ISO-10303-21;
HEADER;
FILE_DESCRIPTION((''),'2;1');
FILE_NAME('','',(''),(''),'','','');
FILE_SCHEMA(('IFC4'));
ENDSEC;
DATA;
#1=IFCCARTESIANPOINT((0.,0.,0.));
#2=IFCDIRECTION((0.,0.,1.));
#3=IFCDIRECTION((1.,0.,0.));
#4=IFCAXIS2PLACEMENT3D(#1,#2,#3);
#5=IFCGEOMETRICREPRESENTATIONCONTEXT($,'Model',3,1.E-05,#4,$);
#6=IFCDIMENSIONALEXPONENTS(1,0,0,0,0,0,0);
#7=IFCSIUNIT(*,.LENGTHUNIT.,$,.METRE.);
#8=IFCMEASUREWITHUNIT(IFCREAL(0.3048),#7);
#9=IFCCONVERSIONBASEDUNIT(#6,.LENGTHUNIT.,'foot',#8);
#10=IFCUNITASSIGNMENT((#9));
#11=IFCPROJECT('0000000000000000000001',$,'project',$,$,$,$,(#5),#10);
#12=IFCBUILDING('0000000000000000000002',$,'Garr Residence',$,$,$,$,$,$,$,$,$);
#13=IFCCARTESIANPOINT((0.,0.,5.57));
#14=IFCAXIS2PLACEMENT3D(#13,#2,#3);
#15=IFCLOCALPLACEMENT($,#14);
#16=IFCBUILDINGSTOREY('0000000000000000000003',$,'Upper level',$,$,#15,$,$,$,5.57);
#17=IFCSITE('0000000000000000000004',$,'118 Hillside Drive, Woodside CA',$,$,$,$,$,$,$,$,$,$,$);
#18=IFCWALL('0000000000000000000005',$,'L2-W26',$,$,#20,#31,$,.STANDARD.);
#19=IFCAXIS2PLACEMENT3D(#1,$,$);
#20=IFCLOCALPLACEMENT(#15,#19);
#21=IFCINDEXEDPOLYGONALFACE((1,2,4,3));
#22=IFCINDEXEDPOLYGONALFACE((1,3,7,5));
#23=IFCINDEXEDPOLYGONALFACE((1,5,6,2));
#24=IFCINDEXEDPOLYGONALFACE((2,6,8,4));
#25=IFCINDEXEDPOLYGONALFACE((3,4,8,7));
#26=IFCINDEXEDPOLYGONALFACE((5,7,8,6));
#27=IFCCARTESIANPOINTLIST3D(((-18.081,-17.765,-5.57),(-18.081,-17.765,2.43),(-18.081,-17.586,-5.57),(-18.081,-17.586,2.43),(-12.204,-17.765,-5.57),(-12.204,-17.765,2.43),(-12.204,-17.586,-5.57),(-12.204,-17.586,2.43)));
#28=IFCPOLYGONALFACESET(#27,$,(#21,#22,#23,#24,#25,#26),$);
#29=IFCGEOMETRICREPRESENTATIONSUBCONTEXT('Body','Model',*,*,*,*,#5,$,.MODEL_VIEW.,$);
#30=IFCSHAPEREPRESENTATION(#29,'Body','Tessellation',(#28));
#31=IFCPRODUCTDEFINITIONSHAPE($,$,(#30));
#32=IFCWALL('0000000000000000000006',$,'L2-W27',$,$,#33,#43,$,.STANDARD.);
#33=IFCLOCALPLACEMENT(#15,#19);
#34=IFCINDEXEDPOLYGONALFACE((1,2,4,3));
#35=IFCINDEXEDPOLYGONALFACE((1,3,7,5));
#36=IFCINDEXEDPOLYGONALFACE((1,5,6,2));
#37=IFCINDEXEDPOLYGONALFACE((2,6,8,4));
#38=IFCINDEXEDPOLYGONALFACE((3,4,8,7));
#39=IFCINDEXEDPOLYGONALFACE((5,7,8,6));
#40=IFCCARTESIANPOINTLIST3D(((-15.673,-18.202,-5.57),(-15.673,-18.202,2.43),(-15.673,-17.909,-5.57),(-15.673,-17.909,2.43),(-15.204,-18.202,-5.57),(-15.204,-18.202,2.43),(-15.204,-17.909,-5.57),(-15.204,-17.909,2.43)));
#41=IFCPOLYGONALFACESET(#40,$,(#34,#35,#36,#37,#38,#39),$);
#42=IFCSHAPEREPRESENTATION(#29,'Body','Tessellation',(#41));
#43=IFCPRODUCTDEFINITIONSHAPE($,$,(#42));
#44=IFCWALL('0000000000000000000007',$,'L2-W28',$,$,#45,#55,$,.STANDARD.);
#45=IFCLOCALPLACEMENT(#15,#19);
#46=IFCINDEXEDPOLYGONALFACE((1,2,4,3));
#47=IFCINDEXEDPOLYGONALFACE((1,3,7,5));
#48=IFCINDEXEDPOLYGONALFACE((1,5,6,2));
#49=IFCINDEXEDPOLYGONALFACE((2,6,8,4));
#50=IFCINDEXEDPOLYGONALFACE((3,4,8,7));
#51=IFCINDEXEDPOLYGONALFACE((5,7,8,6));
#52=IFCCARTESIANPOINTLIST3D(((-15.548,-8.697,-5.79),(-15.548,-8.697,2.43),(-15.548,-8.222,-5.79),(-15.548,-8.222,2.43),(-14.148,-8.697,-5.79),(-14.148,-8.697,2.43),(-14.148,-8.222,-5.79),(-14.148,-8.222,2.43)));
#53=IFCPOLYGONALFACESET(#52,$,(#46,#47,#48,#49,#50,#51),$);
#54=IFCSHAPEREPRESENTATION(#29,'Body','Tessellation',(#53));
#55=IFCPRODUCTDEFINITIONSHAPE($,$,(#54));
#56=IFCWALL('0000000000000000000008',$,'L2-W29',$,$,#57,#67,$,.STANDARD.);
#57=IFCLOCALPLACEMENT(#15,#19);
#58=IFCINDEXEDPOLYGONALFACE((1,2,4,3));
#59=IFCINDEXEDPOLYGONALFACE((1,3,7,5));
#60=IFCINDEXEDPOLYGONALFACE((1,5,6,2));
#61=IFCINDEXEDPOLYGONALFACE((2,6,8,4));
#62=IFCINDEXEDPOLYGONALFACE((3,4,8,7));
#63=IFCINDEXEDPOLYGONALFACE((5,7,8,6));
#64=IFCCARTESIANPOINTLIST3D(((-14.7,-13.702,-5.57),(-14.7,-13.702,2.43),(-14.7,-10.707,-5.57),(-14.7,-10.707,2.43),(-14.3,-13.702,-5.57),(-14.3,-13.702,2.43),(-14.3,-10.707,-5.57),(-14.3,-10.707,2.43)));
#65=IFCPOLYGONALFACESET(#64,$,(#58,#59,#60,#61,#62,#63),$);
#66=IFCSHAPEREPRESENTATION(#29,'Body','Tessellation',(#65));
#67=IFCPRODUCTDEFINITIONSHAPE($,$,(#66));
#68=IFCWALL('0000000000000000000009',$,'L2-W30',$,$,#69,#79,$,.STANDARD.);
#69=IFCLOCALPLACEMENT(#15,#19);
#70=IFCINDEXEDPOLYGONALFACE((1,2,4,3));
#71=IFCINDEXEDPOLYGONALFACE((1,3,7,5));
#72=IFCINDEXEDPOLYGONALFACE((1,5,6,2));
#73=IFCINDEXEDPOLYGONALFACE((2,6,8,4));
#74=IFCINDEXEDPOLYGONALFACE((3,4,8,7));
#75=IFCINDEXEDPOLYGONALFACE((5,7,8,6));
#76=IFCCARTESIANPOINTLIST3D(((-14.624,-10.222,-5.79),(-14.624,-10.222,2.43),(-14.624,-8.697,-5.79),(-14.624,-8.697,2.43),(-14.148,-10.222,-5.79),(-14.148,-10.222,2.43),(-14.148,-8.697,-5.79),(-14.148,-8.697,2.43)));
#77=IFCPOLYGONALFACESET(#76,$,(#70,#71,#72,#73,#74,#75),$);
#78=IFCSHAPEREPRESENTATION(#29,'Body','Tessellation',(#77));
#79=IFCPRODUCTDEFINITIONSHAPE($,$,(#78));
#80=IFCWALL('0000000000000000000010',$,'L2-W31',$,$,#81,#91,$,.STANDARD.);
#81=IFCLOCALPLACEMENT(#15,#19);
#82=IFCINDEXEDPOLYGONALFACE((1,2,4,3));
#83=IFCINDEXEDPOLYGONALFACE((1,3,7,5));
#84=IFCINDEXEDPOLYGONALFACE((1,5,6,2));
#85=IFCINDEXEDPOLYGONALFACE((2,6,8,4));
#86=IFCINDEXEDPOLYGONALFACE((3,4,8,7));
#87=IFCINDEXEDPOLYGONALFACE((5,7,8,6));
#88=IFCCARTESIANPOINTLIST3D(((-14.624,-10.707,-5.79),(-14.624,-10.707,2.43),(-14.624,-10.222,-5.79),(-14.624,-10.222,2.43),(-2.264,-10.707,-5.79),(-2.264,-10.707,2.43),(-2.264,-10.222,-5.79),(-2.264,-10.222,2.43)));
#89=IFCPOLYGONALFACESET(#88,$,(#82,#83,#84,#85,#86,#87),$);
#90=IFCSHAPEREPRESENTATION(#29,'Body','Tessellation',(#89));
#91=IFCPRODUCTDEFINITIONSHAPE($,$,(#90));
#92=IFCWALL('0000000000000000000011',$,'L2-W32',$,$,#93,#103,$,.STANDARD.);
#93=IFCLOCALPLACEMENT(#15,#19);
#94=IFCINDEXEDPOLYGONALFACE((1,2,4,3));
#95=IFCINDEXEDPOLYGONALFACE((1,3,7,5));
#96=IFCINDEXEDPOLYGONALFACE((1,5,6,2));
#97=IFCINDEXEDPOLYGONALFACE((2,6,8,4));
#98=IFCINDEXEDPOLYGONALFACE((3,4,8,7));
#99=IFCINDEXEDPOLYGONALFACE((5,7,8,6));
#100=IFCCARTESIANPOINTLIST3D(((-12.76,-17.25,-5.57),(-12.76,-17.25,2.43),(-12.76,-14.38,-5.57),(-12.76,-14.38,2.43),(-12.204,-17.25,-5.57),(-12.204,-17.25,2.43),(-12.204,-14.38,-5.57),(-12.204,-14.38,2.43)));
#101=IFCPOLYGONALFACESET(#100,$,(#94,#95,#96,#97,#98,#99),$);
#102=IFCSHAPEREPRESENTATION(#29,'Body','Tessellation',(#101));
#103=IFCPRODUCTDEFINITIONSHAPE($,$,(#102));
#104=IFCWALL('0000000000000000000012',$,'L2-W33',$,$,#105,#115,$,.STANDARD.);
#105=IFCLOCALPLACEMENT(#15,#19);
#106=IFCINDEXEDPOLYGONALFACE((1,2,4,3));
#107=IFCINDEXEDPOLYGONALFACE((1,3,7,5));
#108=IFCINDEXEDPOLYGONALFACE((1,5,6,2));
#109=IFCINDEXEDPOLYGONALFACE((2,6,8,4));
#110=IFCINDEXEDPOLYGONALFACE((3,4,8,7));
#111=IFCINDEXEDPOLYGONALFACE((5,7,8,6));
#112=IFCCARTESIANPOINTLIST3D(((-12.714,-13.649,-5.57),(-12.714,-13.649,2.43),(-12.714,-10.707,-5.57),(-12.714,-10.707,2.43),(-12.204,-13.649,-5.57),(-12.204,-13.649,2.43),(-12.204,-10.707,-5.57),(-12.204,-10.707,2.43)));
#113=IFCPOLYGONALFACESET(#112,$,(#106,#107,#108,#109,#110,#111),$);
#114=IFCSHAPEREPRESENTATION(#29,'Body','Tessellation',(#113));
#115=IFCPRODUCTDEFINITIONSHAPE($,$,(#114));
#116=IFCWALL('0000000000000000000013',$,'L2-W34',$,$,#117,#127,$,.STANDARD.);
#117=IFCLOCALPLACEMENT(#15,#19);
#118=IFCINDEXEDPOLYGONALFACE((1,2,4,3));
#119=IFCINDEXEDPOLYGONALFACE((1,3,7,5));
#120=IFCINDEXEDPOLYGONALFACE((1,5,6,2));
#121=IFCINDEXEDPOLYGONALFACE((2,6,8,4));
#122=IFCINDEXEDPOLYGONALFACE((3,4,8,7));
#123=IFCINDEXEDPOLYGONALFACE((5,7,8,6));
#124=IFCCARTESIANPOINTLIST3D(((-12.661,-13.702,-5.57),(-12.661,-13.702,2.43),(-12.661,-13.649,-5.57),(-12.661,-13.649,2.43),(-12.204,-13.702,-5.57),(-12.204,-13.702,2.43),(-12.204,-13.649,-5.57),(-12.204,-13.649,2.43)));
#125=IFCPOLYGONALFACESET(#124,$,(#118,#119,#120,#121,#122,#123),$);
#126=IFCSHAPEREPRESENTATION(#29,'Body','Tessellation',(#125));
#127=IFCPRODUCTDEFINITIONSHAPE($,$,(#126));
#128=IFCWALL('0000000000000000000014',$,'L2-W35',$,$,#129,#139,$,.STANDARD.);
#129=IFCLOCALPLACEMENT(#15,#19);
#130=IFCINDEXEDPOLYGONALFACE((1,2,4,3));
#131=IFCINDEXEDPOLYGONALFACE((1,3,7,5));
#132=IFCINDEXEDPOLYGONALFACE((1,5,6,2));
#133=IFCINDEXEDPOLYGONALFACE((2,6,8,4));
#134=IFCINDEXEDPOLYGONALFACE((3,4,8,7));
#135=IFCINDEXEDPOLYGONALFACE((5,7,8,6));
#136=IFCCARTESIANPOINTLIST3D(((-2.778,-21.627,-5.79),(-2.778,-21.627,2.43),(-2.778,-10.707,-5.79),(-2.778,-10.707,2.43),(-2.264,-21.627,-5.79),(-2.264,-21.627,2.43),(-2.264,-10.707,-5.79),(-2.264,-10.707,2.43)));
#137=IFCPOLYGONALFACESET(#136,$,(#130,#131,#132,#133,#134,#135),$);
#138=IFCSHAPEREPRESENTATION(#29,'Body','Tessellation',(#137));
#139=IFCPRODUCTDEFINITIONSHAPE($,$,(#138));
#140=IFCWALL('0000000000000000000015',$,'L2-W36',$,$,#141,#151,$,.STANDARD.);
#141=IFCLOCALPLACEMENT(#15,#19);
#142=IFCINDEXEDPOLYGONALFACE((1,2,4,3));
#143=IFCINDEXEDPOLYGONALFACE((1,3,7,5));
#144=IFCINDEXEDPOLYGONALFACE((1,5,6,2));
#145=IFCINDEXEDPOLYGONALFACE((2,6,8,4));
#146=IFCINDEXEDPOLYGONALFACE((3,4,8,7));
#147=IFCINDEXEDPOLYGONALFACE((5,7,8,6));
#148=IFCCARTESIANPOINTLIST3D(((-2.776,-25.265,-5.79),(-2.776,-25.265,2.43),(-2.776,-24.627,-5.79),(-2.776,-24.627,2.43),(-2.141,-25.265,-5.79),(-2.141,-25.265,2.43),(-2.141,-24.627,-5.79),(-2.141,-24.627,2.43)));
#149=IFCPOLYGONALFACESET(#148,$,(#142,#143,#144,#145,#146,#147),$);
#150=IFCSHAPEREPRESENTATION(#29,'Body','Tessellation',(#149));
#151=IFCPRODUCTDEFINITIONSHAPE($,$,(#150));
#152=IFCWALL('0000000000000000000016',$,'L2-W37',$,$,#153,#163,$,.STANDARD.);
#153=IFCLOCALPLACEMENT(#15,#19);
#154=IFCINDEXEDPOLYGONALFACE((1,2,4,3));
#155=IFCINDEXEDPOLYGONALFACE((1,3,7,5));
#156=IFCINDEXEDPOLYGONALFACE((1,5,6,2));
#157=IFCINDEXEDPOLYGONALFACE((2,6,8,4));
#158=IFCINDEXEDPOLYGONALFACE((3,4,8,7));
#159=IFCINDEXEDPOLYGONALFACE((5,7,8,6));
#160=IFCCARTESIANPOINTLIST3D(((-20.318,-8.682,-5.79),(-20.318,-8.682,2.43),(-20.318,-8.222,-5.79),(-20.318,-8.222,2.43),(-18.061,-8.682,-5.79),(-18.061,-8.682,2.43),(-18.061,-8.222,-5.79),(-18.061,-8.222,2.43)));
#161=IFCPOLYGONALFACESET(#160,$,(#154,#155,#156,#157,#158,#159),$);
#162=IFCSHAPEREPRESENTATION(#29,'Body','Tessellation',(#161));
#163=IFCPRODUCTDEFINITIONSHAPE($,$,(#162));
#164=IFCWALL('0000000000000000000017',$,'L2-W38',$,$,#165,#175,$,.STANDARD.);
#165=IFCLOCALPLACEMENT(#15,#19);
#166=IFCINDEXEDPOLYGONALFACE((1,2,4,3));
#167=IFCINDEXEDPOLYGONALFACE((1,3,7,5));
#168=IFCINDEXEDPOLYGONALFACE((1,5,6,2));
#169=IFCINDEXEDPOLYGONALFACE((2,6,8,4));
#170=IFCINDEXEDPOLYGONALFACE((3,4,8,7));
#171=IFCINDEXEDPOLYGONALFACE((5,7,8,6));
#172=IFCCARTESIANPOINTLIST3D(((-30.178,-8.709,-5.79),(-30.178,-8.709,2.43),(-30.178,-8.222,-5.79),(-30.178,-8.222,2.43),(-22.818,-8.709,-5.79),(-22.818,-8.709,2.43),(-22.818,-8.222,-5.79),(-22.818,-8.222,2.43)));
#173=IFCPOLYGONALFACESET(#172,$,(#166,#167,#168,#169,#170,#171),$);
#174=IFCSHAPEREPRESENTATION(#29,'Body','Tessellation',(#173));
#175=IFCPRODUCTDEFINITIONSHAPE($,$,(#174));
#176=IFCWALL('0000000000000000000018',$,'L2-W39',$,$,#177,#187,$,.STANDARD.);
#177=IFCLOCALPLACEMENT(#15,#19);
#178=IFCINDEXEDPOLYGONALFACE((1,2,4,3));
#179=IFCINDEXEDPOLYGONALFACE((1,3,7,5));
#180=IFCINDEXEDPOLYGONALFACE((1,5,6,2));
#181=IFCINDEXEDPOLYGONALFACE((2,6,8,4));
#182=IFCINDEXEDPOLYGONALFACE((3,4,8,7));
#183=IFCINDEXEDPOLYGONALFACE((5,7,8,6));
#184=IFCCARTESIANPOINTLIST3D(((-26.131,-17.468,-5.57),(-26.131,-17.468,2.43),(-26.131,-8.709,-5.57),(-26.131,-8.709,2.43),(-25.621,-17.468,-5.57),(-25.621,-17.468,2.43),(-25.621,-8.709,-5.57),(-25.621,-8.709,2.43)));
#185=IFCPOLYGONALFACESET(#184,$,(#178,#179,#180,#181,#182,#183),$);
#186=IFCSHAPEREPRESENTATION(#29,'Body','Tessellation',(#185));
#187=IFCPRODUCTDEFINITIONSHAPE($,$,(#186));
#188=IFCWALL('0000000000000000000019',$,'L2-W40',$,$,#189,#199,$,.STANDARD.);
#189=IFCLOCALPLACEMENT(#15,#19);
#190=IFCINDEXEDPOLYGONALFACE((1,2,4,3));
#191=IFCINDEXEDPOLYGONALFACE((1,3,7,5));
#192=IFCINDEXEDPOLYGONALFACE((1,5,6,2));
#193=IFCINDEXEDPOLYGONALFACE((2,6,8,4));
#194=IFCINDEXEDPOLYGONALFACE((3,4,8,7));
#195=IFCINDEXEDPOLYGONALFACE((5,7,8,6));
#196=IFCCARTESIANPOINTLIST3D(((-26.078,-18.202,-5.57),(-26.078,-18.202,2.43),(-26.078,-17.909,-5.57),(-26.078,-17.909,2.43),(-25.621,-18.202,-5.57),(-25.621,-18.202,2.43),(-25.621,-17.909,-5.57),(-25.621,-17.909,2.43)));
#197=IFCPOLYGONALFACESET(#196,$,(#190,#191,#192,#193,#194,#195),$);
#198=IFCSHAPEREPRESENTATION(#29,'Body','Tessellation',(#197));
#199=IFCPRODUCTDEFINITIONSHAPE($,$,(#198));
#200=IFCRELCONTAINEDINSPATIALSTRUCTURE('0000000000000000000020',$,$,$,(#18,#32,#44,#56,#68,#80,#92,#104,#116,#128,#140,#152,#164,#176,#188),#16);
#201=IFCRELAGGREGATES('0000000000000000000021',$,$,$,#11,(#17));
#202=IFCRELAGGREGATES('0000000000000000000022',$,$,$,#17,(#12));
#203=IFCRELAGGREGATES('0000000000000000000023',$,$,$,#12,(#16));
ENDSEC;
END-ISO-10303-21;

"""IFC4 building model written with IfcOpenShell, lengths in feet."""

from ifc_helpers import new_model, entity, si_unit, converted_unit, frame, origin, origin_with_axes, place, context, subcontext, project, spatial, polyline, outline, extrude, element, save


model = new_model("IFC4")

# Units and contexts
model_context = context("Model", 3, precision=1e-05, world=origin_with_axes())
body_context = subcontext(model_context, "Body", "Model", "MODEL_VIEW")
ifc_project = project(units=[converted_unit("LENGTHUNIT", "foot", entity("IfcReal", 0.3048), si_unit("LENGTHUNIT", "METRE"), dimensions=[1, 0, 0, 0, 0, 0, 0])], contexts=[model_context])

# Site, building, storey
site = spatial("IfcSite", under=ifc_project, Name="118 Hillside Drive, Woodside CA")
building = spatial("IfcBuilding", under=site, Name="Garr Residence")
storey_placement = place(None, frame((0.0, 0.0, 5.57), z_axis=(0.0, 0.0, 1.0), x_axis=(1.0, 0.0, 0.0)))
storey = spatial("IfcBuildingStorey", under=building, at=storey_placement, Name="Upper level", Elevation=5.57)

# Walls
wall_1_placement = place(storey_placement, frame((0.0, 0.0, -5.57), z_axis=(0.0, 0.0, 1.0), x_axis=(1.0, 0.0, 0.0)))
element("IfcWall", 1, at=wall_1_placement, inside=storey, Name="L2-W26", PredefinedType="STANDARD", context=body_context, shape_type="SweptSolid", body=[
    extrude(outline(polyline([(-12.204, -17.765), (-12.204, -17.586), (-18.081, -17.586), (-18.081, -17.765), (-12.204, -17.765)])), origin(), (0.0, 0.0, 1.0), 8.0),
])
wall_2_placement = place(storey_placement, frame((0.0, 0.0, -5.57), z_axis=(0.0, 0.0, 1.0), x_axis=(1.0, 0.0, 0.0)))
element("IfcWall", 2, at=wall_2_placement, inside=storey, Name="L2-W27", PredefinedType="STANDARD", context=body_context, shape_type="SweptSolid", body=[
    extrude(outline(polyline([(-15.204, -18.202), (-15.204, -17.909), (-15.673, -17.909), (-15.673, -18.202), (-15.204, -18.202)])), origin(), (0.0, 0.0, 1.0), 8.0),
])
wall_3_placement = place(storey_placement, frame((0.0, 0.0, -5.79), z_axis=(0.0, 0.0, 1.0), x_axis=(1.0, 0.0, 0.0)))
element("IfcWall", 3, at=wall_3_placement, inside=storey, Name="L2-W28", PredefinedType="STANDARD", context=body_context, shape_type="SweptSolid", body=[
    extrude(outline(polyline([(-14.148, -8.697), (-14.148, -8.222), (-15.548, -8.222), (-15.548, -8.697), (-14.148, -8.697)])), origin(), (0.0, 0.0, 1.0), 8.22),
])
wall_4_placement = place(storey_placement, frame((0.0, 0.0, -5.57), z_axis=(0.0, 0.0, 1.0), x_axis=(1.0, 0.0, 0.0)))
element("IfcWall", 4, at=wall_4_placement, inside=storey, Name="L2-W29", PredefinedType="STANDARD", context=body_context, shape_type="SweptSolid", body=[
    extrude(outline(polyline([(-14.3, -13.702), (-14.3, -10.707), (-14.7, -10.707), (-14.7, -13.702), (-14.3, -13.702)])), origin(), (0.0, 0.0, 1.0), 8.0),
])
wall_5_placement = place(storey_placement, frame((0.0, 0.0, -5.79), z_axis=(0.0, 0.0, 1.0), x_axis=(1.0, 0.0, 0.0)))
element("IfcWall", 5, at=wall_5_placement, inside=storey, Name="L2-W30", PredefinedType="STANDARD", context=body_context, shape_type="SweptSolid", body=[
    extrude(outline(polyline([(-14.148, -10.222), (-14.148, -8.697), (-14.624, -8.697), (-14.624, -10.222), (-14.148, -10.222)])), origin(), (0.0, 0.0, 1.0), 8.22),
])
wall_6_placement = place(storey_placement, frame((0.0, 0.0, -5.79), z_axis=(0.0, 0.0, 1.0), x_axis=(1.0, 0.0, 0.0)))
element("IfcWall", 6, at=wall_6_placement, inside=storey, Name="L2-W31", PredefinedType="STANDARD", context=body_context, shape_type="SweptSolid", body=[
    extrude(outline(polyline([(-2.264, -10.707), (-2.264, -10.222), (-14.624, -10.222), (-14.624, -10.707), (-2.264, -10.707)])), origin(), (0.0, 0.0, 1.0), 8.22),
])
wall_7_placement = place(storey_placement, frame((0.0, 0.0, -5.57), z_axis=(0.0, 0.0, 1.0), x_axis=(1.0, 0.0, 0.0)))
element("IfcWall", 7, at=wall_7_placement, inside=storey, Name="L2-W32", PredefinedType="STANDARD", context=body_context, shape_type="SweptSolid", body=[
    extrude(outline(polyline([(-12.204, -17.25), (-12.204, -14.38), (-12.76, -14.38), (-12.76, -17.25), (-12.204, -17.25)])), origin(), (0.0, 0.0, 1.0), 8.0),
])
wall_8_placement = place(storey_placement, frame((0.0, 0.0, -5.57), z_axis=(0.0, 0.0, 1.0), x_axis=(1.0, 0.0, 0.0)))
element("IfcWall", 8, at=wall_8_placement, inside=storey, Name="L2-W33", PredefinedType="STANDARD", context=body_context, shape_type="SweptSolid", body=[
    extrude(outline(polyline([(-12.204, -13.649), (-12.204, -10.707), (-12.714, -10.707), (-12.714, -13.649), (-12.204, -13.649)])), origin(), (0.0, 0.0, 1.0), 8.0),
])
wall_9_placement = place(storey_placement, frame((0.0, 0.0, -5.57), z_axis=(0.0, 0.0, 1.0), x_axis=(1.0, 0.0, 0.0)))
element("IfcWall", 9, at=wall_9_placement, inside=storey, Name="L2-W34", PredefinedType="STANDARD", context=body_context, shape_type="SweptSolid", body=[
    extrude(outline(polyline([(-12.204, -13.702), (-12.204, -13.649), (-12.661, -13.649), (-12.661, -13.702), (-12.204, -13.702)])), origin(), (0.0, 0.0, 1.0), 8.0),
])
wall_10_placement = place(storey_placement, frame((0.0, 0.0, -5.79), z_axis=(0.0, 0.0, 1.0), x_axis=(1.0, 0.0, 0.0)))
element("IfcWall", 10, at=wall_10_placement, inside=storey, Name="L2-W35", PredefinedType="STANDARD", context=body_context, shape_type="SweptSolid", body=[
    extrude(outline(polyline([(-2.264, -21.627), (-2.264, -10.707), (-2.778, -10.707), (-2.778, -21.627), (-2.264, -21.627)])), origin(), (0.0, 0.0, 1.0), 8.22),
])
wall_11_placement = place(storey_placement, frame((0.0, 0.0, -5.79), z_axis=(0.0, 0.0, 1.0), x_axis=(1.0, 0.0, 0.0)))
element("IfcWall", 11, at=wall_11_placement, inside=storey, Name="L2-W36", PredefinedType="STANDARD", context=body_context, shape_type="SweptSolid", body=[
    extrude(outline(polyline([(-2.141, -25.265), (-2.141, -24.627), (-2.776, -24.627), (-2.776, -25.265), (-2.141, -25.265)])), origin(), (0.0, 0.0, 1.0), 8.22),
])
wall_12_placement = place(storey_placement, frame((0.0, 0.0, -5.79), z_axis=(0.0, 0.0, 1.0), x_axis=(1.0, 0.0, 0.0)))
element("IfcWall", 12, at=wall_12_placement, inside=storey, Name="L2-W37", PredefinedType="STANDARD", context=body_context, shape_type="SweptSolid", body=[
    extrude(outline(polyline([(-18.061, -8.682), (-18.061, -8.222), (-20.318, -8.222), (-20.318, -8.682), (-18.061, -8.682)])), origin(), (0.0, 0.0, 1.0), 8.22),
])
wall_13_placement = place(storey_placement, frame((0.0, 0.0, -5.79), z_axis=(0.0, 0.0, 1.0), x_axis=(1.0, 0.0, 0.0)))
element("IfcWall", 13, at=wall_13_placement, inside=storey, Name="L2-W38", PredefinedType="STANDARD", context=body_context, shape_type="SweptSolid", body=[
    extrude(outline(polyline([(-22.818, -8.709), (-22.818, -8.222), (-30.178, -8.222), (-30.178, -8.709), (-22.818, -8.709)])), origin(), (0.0, 0.0, 1.0), 8.22),
])
wall_14_placement = place(storey_placement, frame((0.0, 0.0, -5.57), z_axis=(0.0, 0.0, 1.0), x_axis=(1.0, 0.0, 0.0)))
element("IfcWall", 14, at=wall_14_placement, inside=storey, Name="L2-W39", PredefinedType="STANDARD", context=body_context, shape_type="SweptSolid", body=[
    extrude(outline(polyline([(-25.621, -17.468), (-25.621, -8.709), (-26.131, -8.709), (-26.131, -17.468), (-25.621, -17.468)])), origin(), (0.0, 0.0, 1.0), 8.0),
])
wall_15_placement = place(storey_placement, frame((0.0, 0.0, -5.57), z_axis=(0.0, 0.0, 1.0), x_axis=(1.0, 0.0, 0.0)))
element("IfcWall", 15, at=wall_15_placement, inside=storey, Name="L2-W40", PredefinedType="STANDARD", context=body_context, shape_type="SweptSolid", body=[
    extrude(outline(polyline([(-25.621, -18.202), (-25.621, -17.909), (-26.078, -17.909), (-26.078, -18.202), (-25.621, -18.202)])), origin(), (0.0, 0.0, 1.0), 8.0),
])

save(model, "model.ifc")
